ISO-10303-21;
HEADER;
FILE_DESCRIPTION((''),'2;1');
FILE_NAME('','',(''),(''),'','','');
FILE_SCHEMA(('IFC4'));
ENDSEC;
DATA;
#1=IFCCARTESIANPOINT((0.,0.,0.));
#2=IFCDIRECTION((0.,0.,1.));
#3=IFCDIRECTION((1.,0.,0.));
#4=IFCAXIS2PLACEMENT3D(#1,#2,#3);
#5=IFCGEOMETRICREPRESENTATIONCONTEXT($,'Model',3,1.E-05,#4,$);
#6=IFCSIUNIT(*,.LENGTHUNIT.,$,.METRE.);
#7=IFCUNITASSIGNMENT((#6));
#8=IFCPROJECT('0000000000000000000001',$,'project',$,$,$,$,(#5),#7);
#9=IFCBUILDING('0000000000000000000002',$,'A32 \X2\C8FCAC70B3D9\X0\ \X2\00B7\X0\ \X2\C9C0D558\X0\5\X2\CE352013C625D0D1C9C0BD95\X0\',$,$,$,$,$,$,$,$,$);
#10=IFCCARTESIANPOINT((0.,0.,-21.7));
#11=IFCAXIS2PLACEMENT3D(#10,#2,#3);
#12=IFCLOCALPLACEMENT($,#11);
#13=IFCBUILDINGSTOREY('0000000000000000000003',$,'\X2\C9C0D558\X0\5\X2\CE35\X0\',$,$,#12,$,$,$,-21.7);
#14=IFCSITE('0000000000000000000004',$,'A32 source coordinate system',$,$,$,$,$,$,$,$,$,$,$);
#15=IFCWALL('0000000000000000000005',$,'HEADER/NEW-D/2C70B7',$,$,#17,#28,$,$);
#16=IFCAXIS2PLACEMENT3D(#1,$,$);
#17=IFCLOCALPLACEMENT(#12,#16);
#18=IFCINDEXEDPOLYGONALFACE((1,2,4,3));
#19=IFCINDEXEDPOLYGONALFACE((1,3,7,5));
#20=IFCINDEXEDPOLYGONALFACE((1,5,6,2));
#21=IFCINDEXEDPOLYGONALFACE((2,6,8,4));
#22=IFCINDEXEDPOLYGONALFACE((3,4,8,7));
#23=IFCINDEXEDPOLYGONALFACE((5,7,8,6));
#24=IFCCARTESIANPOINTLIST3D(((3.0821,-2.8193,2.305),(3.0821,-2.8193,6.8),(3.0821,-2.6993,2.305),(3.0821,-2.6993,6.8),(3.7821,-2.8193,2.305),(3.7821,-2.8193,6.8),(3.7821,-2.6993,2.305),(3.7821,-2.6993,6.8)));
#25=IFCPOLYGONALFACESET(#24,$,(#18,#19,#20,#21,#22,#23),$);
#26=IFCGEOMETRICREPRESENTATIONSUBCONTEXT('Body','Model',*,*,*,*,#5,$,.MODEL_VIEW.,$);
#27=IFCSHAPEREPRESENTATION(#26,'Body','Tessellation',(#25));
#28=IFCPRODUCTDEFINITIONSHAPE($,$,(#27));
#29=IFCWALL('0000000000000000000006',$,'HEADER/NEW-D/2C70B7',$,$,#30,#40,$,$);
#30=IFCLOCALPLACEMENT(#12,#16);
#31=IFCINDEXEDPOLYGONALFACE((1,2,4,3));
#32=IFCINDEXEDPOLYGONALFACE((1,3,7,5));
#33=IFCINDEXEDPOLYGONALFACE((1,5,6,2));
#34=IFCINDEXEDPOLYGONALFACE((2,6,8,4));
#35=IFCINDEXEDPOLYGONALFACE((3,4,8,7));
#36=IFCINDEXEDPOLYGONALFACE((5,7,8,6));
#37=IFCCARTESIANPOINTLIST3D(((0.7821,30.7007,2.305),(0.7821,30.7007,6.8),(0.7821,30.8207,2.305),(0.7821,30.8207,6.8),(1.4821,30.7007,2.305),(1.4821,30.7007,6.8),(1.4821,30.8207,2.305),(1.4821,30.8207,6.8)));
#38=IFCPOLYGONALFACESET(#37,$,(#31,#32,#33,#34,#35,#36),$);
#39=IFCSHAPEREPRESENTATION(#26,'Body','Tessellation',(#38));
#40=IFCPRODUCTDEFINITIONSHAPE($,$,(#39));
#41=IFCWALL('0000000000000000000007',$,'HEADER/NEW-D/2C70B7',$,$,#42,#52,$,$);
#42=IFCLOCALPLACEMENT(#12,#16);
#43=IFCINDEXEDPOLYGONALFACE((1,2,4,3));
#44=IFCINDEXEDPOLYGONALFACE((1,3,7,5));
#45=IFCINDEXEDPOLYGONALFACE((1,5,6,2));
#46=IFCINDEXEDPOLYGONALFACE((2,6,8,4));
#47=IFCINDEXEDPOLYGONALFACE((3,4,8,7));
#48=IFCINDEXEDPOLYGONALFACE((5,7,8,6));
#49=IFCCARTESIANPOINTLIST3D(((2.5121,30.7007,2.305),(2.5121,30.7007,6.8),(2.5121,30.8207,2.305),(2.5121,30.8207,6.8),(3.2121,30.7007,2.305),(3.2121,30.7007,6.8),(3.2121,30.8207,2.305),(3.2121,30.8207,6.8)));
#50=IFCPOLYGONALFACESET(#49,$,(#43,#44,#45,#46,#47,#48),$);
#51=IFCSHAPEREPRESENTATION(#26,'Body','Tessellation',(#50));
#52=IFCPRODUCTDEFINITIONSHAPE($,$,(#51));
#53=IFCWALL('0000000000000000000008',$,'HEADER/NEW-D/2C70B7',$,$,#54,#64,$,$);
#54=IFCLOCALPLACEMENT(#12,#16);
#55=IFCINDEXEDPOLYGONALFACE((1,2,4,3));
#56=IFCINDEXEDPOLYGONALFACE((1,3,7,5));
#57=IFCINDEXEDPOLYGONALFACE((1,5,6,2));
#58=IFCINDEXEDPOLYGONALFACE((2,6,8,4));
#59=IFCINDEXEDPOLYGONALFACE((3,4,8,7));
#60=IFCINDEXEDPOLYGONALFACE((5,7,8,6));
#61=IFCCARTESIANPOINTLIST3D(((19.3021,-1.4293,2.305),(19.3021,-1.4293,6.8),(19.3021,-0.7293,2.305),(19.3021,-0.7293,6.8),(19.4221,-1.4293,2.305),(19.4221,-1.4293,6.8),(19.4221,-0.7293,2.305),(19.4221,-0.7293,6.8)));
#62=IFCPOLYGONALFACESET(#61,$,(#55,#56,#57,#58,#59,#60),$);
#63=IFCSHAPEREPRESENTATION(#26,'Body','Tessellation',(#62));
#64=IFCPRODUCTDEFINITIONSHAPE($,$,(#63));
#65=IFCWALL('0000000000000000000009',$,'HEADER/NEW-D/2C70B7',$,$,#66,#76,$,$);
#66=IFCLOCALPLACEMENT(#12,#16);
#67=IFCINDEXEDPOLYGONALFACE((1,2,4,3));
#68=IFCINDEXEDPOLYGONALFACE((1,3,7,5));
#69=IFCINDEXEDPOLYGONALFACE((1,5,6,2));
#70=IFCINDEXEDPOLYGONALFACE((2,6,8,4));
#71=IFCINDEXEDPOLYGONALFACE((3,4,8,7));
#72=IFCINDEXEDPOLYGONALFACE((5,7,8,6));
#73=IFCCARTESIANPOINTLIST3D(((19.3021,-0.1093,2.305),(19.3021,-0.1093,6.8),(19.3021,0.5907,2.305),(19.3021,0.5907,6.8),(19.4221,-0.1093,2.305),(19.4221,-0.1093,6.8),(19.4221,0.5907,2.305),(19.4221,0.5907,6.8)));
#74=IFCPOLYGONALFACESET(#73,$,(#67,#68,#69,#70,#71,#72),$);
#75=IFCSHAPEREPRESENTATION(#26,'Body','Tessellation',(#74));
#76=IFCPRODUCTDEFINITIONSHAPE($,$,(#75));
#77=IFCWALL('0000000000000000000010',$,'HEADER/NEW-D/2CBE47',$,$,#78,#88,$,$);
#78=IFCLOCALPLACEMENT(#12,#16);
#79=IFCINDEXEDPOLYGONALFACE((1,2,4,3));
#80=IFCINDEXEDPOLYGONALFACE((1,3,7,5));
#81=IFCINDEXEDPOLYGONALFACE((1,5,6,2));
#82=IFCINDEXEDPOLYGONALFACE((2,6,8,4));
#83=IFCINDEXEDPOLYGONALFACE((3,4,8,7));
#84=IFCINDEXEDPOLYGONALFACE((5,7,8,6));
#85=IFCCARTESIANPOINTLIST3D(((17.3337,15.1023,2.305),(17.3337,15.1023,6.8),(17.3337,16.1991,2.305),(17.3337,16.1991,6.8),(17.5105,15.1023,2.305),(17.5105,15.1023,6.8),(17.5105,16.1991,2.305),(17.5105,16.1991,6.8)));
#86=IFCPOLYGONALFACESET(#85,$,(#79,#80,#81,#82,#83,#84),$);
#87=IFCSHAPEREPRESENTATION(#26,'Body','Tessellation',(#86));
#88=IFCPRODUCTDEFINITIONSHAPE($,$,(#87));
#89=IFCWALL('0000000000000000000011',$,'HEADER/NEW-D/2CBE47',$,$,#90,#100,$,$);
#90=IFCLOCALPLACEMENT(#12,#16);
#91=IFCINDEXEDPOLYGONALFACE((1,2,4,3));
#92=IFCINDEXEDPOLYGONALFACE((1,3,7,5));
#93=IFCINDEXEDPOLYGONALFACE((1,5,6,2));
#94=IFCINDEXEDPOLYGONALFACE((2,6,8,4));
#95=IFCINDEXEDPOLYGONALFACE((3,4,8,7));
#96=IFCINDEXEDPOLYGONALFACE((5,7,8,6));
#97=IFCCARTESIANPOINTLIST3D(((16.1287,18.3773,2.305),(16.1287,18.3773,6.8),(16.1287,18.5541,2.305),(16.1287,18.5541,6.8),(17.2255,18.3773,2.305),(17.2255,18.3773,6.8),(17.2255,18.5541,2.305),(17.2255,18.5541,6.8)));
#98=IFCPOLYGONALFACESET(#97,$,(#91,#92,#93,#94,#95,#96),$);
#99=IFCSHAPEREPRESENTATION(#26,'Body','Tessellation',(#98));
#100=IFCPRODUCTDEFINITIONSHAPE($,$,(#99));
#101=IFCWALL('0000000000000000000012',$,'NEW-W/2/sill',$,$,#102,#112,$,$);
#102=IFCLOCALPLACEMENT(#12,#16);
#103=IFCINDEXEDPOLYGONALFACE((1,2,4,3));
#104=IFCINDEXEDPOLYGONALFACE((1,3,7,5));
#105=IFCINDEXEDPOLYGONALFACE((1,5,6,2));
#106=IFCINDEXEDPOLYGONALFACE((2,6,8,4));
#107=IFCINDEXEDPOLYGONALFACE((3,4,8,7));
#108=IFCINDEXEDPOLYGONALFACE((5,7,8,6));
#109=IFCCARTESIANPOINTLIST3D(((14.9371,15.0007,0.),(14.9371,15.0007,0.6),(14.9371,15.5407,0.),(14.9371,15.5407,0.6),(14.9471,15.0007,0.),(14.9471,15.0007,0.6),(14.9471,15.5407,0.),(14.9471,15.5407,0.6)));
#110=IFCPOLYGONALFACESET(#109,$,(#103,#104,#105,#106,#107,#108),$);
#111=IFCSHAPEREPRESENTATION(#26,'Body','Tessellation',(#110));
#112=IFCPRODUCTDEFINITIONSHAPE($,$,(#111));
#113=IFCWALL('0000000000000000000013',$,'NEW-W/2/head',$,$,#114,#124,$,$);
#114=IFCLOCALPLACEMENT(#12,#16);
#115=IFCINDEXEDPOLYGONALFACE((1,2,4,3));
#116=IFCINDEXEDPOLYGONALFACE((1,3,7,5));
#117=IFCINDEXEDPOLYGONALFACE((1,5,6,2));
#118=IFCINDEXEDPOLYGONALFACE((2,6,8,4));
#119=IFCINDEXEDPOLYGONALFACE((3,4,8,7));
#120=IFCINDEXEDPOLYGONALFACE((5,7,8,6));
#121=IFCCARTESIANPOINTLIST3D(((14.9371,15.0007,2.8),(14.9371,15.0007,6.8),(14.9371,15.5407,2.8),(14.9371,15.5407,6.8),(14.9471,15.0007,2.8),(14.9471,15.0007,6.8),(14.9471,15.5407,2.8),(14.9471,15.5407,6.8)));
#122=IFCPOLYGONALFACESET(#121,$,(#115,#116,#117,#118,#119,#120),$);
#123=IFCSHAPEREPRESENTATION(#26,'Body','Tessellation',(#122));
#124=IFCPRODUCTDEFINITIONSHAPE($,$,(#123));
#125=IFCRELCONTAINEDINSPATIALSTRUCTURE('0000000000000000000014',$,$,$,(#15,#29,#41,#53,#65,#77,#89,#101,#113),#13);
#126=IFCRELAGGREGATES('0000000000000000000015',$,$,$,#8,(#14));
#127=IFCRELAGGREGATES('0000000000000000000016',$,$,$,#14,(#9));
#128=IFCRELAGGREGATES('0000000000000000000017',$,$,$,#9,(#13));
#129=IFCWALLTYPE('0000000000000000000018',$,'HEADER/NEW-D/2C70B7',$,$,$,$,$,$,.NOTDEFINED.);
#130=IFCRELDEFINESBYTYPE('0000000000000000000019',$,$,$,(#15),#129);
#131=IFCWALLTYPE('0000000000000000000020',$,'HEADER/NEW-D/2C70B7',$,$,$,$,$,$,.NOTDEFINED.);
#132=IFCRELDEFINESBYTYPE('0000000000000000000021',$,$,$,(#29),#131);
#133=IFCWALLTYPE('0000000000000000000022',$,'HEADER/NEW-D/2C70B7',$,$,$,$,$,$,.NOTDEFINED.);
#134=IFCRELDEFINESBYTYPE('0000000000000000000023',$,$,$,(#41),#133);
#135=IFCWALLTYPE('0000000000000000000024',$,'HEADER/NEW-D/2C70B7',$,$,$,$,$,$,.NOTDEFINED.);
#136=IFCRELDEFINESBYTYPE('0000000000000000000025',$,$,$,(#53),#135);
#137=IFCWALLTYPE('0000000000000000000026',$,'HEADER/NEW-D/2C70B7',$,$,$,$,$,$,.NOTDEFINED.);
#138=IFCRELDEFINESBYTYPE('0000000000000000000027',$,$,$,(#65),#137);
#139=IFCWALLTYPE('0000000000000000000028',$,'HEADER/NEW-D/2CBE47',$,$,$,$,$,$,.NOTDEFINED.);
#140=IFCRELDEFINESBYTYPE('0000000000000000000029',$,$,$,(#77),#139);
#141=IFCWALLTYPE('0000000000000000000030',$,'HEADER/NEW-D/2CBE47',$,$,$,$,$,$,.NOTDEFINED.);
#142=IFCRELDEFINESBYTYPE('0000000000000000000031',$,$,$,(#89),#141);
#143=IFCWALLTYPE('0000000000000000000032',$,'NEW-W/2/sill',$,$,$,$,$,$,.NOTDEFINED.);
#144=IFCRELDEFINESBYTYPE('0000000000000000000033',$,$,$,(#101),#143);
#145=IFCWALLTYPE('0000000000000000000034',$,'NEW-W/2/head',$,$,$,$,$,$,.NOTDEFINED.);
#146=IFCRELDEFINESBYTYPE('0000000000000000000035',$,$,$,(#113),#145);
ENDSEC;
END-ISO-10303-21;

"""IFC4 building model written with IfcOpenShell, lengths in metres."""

from ifc_helpers import new_model, si_unit, frame, origin, origin_with_axes, place, context, subcontext, project, spatial, polyline, outline, extrude, source, transform, mapped, type_object, type_shapes, element, save


model = new_model("IFC4")

# Units and contexts
model_context = context("Model", 3, precision=1e-05, world=origin_with_axes())
body_context = subcontext(model_context, "Body", "Model", "MODEL_VIEW")
ifc_project = project(units=[si_unit("LENGTHUNIT", "METRE")], contexts=[model_context])

# Site, building, storey
site = spatial("IfcSite", under=ifc_project, Name="A32 source coordinate system")
building = spatial("IfcBuilding", under=site, Name="A32 주거동 · 지하5층–옥탑지붕")
storey_placement = place(None, frame((0.0, 0.0, -21.7), z_axis=(0.0, 0.0, 1.0), x_axis=(1.0, 0.0, 0.0)))
storey = spatial("IfcBuildingStorey", under=building, at=storey_placement, Name="지하5층", Elevation=-21.7)

# Walls
wall_type_1 = type_object("IfcWallType", Name="HEADER/NEW-D/2C70B7", PredefinedType="NOTDEFINED")
shared_shape_1 = source(origin(), body_context, "Body", "SweptSolid", [
    extrude(outline(polyline([(3.0821, -2.8193), (3.0821, -2.6993), (3.7821, -2.6993), (3.7821, -2.8193), (3.0821, -2.8193)])), frame((0.0, 0.0, 2.305)), (0.0, 0.0, 1.0), 4.495),
])
type_shapes(wall_type_1, [shared_shape_1])
wall_1_placement = place(storey_placement, origin_with_axes())
element("IfcWall", 1, at=wall_1_placement, inside=storey, type_object=wall_type_1, Name="HEADER/NEW-D/2C70B7", context=body_context, shape_type="MappedRepresentation", body=[
    mapped(shared_shape_1, transform((0.0, 0.0, 0.0), scale=1.0)),
])
wall_type_2 = type_object("IfcWallType", Name="HEADER/NEW-D/2C70B7", PredefinedType="NOTDEFINED")
shared_shape_2 = source(origin(), body_context, "Body", "SweptSolid", [
    extrude(outline(polyline([(0.7821, 30.7007), (0.7821, 30.8207), (1.4821, 30.8207), (1.4821, 30.7007), (0.7821, 30.7007)])), frame((0.0, 0.0, 2.305)), (0.0, 0.0, 1.0), 4.495),
])
type_shapes(wall_type_2, [shared_shape_2])
wall_2_placement = place(storey_placement, origin_with_axes())
element("IfcWall", 2, at=wall_2_placement, inside=storey, type_object=wall_type_2, Name="HEADER/NEW-D/2C70B7", context=body_context, shape_type="MappedRepresentation", body=[
    mapped(shared_shape_2, transform((0.0, 0.0, 0.0), scale=1.0)),
])
wall_type_3 = type_object("IfcWallType", Name="HEADER/NEW-D/2C70B7", PredefinedType="NOTDEFINED")
shared_shape_3 = source(origin(), body_context, "Body", "SweptSolid", [
    extrude(outline(polyline([(2.5121, 30.7007), (2.5121, 30.8207), (3.2121, 30.8207), (3.2121, 30.7007), (2.5121, 30.7007)])), frame((0.0, 0.0, 2.305)), (0.0, 0.0, 1.0), 4.495),
])
type_shapes(wall_type_3, [shared_shape_3])
wall_3_placement = place(storey_placement, origin_with_axes())
element("IfcWall", 3, at=wall_3_placement, inside=storey, type_object=wall_type_3, Name="HEADER/NEW-D/2C70B7", context=body_context, shape_type="MappedRepresentation", body=[
    mapped(shared_shape_3, transform((0.0, 0.0, 0.0), scale=1.0)),
])
wall_type_4 = type_object("IfcWallType", Name="HEADER/NEW-D/2C70B7", PredefinedType="NOTDEFINED")
shared_shape_4 = source(origin(), body_context, "Body", "SweptSolid", [
    extrude(outline(polyline([(19.3021, -1.4293), (19.3021, -0.7293), (19.4221, -0.7293), (19.4221, -1.4293), (19.3021, -1.4293)])), frame((0.0, 0.0, 2.305)), (0.0, 0.0, 1.0), 4.495),
])
type_shapes(wall_type_4, [shared_shape_4])
wall_4_placement = place(storey_placement, origin_with_axes())
element("IfcWall", 4, at=wall_4_placement, inside=storey, type_object=wall_type_4, Name="HEADER/NEW-D/2C70B7", context=body_context, shape_type="MappedRepresentation", body=[
    mapped(shared_shape_4, transform((0.0, 0.0, 0.0), scale=1.0)),
])
wall_type_5 = type_object("IfcWallType", Name="HEADER/NEW-D/2C70B7", PredefinedType="NOTDEFINED")
shared_shape_5 = source(origin(), body_context, "Body", "SweptSolid", [
    extrude(outline(polyline([(19.3021, -0.1093), (19.3021, 0.5907), (19.4221, 0.5907), (19.4221, -0.1093), (19.3021, -0.1093)])), frame((0.0, 0.0, 2.305)), (0.0, 0.0, 1.0), 4.495),
])
type_shapes(wall_type_5, [shared_shape_5])
wall_5_placement = place(storey_placement, origin_with_axes())
element("IfcWall", 5, at=wall_5_placement, inside=storey, type_object=wall_type_5, Name="HEADER/NEW-D/2C70B7", context=body_context, shape_type="MappedRepresentation", body=[
    mapped(shared_shape_5, transform((0.0, 0.0, 0.0), scale=1.0)),
])
wall_type_6 = type_object("IfcWallType", Name="HEADER/NEW-D/2CBE47", PredefinedType="NOTDEFINED")
shared_shape_6 = source(origin(), body_context, "Body", "SweptSolid", [
    extrude(outline(polyline([(17.3337, 15.1023), (17.3337, 16.1991), (17.5105, 16.1991), (17.5105, 15.1023), (17.3337, 15.1023)])), frame((0.0, 0.0, 2.305)), (0.0, 0.0, 1.0), 4.495),
])
type_shapes(wall_type_6, [shared_shape_6])
wall_6_placement = place(storey_placement, origin_with_axes())
element("IfcWall", 6, at=wall_6_placement, inside=storey, type_object=wall_type_6, Name="HEADER/NEW-D/2CBE47", context=body_context, shape_type="MappedRepresentation", body=[
    mapped(shared_shape_6, transform((0.0, 0.0, 0.0), scale=1.0)),
])
wall_type_7 = type_object("IfcWallType", Name="HEADER/NEW-D/2CBE47", PredefinedType="NOTDEFINED")
shared_shape_7 = source(origin(), body_context, "Body", "SweptSolid", [
    extrude(outline(polyline([(16.1287, 18.3773), (16.1287, 18.5541), (17.2255, 18.5541), (17.2255, 18.3773), (16.1287, 18.3773)])), frame((0.0, 0.0, 2.305)), (0.0, 0.0, 1.0), 4.495),
])
type_shapes(wall_type_7, [shared_shape_7])
wall_7_placement = place(storey_placement, origin_with_axes())
element("IfcWall", 7, at=wall_7_placement, inside=storey, type_object=wall_type_7, Name="HEADER/NEW-D/2CBE47", context=body_context, shape_type="MappedRepresentation", body=[
    mapped(shared_shape_7, transform((0.0, 0.0, 0.0), scale=1.0)),
])
wall_type_8 = type_object("IfcWallType", Name="NEW-W/2/sill", PredefinedType="NOTDEFINED")
shared_shape_8 = source(origin(), body_context, "Body", "SweptSolid", [
    extrude(outline(polyline([(14.9471, 15.5407), (14.9471, 15.0007), (14.9371, 15.0007), (14.9371, 15.5407), (14.9471, 15.5407)])), origin(), (0.0, 0.0, 1.0), 0.6),
])
type_shapes(wall_type_8, [shared_shape_8])
wall_8_placement = place(storey_placement, origin_with_axes())
element("IfcWall", 8, at=wall_8_placement, inside=storey, type_object=wall_type_8, Name="NEW-W/2/sill", context=body_context, shape_type="MappedRepresentation", body=[
    mapped(shared_shape_8, transform((0.0, 0.0, 0.0), scale=1.0)),
])
wall_type_9 = type_object("IfcWallType", Name="NEW-W/2/head", PredefinedType="NOTDEFINED")
shared_shape_9 = source(origin(), body_context, "Body", "SweptSolid", [
    extrude(outline(polyline([(14.9471, 15.5407), (14.9471, 15.0007), (14.9371, 15.0007), (14.9371, 15.5407), (14.9471, 15.5407)])), frame((0.0, 0.0, 2.8)), (0.0, 0.0, 1.0), 4.0),
])
type_shapes(wall_type_9, [shared_shape_9])
wall_9_placement = place(storey_placement, origin_with_axes())
element("IfcWall", 9, at=wall_9_placement, inside=storey, type_object=wall_type_9, Name="NEW-W/2/head", context=body_context, shape_type="MappedRepresentation", body=[
    mapped(shared_shape_9, transform((0.0, 0.0, 0.0), scale=1.0)),
])

save(model, "model.ifc")
